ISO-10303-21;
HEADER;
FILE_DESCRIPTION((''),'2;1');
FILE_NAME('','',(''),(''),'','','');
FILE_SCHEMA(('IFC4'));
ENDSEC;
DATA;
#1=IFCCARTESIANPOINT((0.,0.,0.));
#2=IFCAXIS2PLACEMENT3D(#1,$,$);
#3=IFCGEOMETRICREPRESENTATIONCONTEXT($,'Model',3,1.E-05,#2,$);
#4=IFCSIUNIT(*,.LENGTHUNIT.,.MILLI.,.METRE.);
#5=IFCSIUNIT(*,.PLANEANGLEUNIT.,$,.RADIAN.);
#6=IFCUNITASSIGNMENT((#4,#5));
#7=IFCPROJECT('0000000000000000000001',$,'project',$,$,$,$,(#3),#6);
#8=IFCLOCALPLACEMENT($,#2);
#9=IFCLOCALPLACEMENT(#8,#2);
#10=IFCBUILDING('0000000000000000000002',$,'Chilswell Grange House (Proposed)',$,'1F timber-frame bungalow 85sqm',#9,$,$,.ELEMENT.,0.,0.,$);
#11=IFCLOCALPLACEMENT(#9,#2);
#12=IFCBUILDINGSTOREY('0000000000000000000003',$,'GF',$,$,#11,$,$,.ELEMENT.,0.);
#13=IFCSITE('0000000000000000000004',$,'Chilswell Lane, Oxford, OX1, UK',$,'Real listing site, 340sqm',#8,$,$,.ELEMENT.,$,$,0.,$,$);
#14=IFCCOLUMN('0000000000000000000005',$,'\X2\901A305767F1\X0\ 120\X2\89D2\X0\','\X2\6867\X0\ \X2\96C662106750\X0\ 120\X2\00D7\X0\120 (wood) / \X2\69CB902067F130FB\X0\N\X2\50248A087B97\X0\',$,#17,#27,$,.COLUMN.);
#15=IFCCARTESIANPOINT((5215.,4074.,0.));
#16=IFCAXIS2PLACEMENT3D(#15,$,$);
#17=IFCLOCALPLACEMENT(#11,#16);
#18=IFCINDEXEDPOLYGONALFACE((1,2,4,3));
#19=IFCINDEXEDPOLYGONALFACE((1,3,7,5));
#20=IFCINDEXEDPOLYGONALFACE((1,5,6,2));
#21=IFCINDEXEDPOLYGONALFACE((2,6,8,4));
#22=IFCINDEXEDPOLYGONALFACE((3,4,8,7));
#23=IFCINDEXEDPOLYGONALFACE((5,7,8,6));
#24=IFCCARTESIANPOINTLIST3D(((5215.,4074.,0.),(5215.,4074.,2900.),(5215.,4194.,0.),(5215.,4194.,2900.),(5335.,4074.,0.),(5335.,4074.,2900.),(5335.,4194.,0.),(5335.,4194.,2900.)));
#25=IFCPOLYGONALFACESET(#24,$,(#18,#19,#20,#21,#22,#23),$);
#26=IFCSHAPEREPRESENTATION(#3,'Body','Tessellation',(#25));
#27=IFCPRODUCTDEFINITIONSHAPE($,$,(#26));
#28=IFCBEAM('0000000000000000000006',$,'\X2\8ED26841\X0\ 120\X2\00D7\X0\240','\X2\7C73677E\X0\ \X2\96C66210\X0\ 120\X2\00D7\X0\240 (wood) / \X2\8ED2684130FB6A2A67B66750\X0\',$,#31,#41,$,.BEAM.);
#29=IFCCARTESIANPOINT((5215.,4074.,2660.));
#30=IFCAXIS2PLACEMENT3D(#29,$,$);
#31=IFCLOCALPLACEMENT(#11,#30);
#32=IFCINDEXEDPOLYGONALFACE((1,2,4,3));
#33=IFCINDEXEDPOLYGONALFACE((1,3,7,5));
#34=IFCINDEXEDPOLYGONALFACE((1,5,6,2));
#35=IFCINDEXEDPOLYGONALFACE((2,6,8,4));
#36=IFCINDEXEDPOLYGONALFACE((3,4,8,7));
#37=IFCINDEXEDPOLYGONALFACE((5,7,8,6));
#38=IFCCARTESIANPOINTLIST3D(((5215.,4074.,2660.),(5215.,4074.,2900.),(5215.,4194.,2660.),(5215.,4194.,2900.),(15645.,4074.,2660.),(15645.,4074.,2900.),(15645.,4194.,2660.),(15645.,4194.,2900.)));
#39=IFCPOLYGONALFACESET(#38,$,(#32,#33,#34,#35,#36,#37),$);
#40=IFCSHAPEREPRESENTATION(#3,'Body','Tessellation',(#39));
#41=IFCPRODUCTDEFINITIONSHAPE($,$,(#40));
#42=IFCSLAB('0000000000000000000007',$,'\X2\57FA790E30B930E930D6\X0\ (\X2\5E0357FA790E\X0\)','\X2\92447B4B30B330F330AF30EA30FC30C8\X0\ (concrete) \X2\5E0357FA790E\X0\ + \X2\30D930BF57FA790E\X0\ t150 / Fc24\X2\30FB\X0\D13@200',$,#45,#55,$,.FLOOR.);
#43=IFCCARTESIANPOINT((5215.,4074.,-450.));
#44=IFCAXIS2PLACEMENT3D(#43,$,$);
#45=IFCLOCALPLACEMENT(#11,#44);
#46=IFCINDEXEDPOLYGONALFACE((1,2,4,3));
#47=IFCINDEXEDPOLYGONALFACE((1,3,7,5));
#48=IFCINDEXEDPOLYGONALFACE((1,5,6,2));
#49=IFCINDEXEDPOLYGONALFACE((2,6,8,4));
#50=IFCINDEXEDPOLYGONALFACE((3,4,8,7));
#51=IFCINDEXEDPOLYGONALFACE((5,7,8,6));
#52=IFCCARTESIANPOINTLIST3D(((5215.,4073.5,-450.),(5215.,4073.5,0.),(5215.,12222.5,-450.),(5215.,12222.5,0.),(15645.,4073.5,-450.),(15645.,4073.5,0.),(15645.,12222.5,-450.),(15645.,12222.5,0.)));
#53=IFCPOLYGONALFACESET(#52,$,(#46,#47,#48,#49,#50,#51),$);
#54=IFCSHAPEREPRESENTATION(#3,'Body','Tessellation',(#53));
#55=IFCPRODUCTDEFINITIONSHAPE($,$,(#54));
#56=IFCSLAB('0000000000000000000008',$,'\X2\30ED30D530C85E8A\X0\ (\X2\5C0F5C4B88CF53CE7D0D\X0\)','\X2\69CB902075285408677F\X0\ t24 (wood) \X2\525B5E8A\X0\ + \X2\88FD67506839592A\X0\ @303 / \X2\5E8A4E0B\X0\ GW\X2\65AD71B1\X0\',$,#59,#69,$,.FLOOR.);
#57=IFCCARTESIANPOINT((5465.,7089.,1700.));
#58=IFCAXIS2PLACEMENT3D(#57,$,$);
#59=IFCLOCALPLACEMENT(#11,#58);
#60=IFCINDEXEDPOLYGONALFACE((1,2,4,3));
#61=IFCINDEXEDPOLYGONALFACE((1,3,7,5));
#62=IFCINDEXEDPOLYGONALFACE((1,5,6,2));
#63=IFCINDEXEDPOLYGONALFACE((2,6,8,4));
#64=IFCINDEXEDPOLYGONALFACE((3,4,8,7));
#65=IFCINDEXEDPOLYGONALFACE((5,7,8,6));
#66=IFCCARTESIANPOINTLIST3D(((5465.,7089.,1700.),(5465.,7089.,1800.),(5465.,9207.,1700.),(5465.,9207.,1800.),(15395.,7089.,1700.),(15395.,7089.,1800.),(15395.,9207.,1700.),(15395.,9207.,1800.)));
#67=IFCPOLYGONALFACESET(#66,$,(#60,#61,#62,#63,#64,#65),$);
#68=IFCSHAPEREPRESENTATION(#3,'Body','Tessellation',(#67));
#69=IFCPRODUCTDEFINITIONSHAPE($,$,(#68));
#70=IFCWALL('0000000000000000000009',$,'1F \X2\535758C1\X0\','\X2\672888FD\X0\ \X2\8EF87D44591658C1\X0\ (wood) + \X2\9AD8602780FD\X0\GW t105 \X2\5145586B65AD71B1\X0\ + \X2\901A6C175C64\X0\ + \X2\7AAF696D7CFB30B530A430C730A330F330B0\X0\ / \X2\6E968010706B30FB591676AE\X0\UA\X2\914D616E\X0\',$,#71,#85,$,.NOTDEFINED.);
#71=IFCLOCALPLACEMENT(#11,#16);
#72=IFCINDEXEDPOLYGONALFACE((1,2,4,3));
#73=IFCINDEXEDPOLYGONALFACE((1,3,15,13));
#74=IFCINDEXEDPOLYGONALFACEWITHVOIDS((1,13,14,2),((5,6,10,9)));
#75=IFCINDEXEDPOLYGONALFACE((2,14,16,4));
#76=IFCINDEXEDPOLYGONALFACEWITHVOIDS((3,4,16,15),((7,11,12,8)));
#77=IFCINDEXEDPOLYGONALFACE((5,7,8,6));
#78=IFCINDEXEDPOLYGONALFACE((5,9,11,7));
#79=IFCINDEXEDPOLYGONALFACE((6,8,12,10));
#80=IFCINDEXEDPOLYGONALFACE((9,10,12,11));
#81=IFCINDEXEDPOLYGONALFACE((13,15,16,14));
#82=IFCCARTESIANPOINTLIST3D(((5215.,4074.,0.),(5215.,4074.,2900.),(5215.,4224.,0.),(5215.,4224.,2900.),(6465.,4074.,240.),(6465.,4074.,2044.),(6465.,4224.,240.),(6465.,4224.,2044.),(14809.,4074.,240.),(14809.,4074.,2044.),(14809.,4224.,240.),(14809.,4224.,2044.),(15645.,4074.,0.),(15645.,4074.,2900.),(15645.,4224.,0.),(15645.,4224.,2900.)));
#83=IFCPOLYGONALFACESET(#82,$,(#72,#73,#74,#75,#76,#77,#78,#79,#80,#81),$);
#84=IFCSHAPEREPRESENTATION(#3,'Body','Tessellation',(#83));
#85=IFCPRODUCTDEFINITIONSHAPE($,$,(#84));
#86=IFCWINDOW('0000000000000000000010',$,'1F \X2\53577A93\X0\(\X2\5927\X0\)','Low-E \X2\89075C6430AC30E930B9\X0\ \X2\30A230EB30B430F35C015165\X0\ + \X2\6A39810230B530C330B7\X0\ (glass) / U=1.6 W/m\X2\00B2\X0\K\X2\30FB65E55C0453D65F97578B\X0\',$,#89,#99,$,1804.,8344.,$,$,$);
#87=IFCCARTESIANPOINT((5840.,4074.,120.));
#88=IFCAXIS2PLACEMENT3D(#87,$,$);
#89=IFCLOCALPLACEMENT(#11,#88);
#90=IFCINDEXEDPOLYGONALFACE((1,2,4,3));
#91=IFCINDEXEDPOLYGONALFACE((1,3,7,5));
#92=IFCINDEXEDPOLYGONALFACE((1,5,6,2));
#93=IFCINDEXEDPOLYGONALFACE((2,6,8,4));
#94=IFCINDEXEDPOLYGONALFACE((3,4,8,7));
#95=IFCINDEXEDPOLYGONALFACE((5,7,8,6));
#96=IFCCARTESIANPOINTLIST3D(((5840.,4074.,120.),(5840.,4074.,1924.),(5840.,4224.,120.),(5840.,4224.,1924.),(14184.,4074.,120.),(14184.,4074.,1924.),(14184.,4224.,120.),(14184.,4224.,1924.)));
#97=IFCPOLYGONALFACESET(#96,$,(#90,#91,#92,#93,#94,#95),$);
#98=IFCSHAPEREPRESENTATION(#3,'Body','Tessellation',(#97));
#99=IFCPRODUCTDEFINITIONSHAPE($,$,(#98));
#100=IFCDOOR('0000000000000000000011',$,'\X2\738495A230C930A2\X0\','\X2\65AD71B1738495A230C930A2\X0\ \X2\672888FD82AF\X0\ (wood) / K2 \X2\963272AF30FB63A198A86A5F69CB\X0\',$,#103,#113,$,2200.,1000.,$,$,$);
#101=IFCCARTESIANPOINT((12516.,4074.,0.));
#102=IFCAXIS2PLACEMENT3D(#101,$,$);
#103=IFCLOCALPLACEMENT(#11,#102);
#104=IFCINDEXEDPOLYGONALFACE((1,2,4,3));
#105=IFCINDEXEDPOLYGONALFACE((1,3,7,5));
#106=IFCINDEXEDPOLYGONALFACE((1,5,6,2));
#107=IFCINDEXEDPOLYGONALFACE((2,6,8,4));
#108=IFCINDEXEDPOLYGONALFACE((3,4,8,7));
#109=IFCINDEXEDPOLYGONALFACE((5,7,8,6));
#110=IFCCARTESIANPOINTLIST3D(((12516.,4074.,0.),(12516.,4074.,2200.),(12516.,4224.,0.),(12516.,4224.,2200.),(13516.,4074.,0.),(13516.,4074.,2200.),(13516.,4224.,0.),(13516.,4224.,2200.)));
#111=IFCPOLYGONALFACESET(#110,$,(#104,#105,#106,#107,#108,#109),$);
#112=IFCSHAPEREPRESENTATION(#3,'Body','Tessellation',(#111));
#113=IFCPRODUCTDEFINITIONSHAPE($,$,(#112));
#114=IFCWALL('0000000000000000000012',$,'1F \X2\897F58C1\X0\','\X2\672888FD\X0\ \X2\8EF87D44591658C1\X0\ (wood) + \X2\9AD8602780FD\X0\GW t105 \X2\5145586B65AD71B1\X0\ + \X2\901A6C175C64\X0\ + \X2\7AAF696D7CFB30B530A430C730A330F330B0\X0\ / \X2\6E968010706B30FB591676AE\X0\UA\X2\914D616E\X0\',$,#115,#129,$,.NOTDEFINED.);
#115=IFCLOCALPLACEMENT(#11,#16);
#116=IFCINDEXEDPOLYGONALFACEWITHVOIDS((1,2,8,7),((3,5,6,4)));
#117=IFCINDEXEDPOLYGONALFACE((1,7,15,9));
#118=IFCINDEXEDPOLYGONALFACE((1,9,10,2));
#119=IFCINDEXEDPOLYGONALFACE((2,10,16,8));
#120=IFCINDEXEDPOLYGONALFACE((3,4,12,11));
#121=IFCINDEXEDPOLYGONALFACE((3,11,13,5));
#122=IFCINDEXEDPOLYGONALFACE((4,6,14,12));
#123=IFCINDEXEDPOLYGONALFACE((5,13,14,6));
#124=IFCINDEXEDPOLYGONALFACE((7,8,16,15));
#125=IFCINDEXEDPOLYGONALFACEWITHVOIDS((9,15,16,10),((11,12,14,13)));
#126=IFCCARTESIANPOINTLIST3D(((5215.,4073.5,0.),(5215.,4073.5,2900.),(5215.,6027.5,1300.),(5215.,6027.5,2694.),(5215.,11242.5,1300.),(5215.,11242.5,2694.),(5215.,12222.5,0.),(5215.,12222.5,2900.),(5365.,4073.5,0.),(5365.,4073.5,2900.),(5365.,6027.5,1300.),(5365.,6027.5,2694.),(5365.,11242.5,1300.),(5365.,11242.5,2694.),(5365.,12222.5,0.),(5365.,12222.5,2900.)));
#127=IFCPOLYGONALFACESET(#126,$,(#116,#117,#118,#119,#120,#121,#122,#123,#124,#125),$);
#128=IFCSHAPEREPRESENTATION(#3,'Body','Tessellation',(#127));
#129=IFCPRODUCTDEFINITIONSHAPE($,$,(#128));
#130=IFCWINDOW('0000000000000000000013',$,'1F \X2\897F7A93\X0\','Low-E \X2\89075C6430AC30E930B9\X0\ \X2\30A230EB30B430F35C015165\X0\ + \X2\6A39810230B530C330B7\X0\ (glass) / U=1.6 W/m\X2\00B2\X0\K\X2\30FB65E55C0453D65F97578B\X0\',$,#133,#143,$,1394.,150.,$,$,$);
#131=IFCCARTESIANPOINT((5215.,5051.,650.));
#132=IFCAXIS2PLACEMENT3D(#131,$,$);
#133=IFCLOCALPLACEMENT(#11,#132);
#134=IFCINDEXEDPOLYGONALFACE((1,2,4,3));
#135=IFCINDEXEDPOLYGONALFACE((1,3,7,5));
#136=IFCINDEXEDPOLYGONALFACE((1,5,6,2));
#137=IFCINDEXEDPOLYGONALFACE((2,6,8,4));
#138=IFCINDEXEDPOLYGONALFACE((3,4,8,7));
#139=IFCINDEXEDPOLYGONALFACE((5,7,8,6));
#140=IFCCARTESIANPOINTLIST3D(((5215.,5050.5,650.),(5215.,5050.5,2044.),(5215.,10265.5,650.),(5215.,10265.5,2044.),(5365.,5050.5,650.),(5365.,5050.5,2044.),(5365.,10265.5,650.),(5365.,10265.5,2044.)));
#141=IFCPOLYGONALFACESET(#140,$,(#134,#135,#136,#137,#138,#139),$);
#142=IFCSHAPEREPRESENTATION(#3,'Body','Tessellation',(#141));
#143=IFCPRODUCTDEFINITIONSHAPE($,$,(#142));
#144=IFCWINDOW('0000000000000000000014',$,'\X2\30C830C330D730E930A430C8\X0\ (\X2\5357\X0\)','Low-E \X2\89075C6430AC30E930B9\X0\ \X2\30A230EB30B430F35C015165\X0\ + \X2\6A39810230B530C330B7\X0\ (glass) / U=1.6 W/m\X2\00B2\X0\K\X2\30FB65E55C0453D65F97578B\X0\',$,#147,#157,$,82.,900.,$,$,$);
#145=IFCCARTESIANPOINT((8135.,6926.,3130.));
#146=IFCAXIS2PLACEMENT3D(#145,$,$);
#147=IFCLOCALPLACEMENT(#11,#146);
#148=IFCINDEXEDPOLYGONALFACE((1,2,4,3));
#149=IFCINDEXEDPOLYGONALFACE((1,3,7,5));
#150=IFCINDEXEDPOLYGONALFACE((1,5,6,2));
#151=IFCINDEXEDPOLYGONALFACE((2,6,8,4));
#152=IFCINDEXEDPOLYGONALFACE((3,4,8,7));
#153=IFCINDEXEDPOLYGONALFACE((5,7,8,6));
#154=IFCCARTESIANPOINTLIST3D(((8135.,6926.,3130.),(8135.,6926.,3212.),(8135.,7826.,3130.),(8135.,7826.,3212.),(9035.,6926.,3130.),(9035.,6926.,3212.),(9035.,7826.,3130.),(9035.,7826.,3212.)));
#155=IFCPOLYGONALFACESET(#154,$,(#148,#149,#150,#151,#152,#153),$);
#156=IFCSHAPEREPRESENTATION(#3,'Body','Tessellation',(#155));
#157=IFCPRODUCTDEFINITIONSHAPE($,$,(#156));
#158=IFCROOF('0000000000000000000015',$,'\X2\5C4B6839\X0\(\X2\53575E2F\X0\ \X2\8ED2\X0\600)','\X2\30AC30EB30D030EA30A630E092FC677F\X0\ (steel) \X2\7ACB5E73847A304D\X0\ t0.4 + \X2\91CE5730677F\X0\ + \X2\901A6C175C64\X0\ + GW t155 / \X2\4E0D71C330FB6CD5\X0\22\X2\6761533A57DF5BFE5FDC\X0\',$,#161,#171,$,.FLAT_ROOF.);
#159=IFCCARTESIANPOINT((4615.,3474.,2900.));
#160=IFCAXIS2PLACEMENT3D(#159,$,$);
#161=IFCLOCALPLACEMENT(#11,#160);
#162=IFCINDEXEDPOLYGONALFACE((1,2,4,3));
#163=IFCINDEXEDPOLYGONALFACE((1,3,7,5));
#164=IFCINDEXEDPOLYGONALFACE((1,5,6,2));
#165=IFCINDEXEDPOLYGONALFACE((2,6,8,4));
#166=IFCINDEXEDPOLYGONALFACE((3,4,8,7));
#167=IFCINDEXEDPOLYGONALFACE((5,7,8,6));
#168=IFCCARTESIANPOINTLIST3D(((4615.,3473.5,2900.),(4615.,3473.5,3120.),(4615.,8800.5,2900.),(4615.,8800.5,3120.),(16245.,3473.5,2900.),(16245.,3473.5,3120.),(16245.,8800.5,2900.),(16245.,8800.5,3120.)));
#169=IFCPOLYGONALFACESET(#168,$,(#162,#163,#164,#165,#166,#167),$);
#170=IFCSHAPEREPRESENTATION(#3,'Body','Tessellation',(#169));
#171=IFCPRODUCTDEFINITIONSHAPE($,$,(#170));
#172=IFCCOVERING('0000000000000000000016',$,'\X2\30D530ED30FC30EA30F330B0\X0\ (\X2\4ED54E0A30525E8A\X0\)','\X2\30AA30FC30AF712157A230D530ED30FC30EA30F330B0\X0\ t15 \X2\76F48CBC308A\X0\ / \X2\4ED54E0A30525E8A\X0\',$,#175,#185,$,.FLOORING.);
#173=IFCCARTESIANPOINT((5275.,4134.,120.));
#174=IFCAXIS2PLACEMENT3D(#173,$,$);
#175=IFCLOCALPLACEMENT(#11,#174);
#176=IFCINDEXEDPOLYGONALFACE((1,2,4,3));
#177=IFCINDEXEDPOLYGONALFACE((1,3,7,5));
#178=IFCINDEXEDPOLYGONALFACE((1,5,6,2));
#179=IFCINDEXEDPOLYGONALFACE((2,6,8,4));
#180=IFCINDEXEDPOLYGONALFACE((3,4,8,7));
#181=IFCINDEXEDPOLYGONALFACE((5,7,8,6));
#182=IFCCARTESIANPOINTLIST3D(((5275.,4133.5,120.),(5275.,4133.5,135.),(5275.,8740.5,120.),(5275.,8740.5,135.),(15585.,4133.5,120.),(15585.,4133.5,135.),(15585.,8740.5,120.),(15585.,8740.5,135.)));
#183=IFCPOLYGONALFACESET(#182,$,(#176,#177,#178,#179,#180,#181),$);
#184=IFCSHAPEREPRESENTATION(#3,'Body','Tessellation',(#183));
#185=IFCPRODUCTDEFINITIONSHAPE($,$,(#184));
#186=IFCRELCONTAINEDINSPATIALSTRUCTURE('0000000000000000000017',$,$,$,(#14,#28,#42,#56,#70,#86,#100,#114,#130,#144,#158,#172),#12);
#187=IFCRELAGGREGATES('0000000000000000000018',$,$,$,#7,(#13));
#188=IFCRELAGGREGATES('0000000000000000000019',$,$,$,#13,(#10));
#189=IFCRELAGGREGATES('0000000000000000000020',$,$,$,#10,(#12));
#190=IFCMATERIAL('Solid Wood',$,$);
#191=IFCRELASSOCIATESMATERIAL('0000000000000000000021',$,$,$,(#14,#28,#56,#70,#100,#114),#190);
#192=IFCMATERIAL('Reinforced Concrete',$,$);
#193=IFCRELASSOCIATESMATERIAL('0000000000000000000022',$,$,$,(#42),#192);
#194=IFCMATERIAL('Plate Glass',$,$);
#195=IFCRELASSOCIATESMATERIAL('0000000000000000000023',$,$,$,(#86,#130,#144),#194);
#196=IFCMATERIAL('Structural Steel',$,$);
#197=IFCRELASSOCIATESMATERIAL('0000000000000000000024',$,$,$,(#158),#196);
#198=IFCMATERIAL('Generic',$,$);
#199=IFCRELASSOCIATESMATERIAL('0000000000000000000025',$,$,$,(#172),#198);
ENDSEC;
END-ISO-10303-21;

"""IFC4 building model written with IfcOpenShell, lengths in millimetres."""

from ifc_helpers import new_model, si_unit, frame, frame_2d, origin, place, context, project, spatial, rectangle, extrude, material, element, fill, save


model = new_model("IFC4")

# Units and contexts
model_context = context("Model", 3, precision=1e-05, world=origin())
ifc_project = project(units=[si_unit("LENGTHUNIT", "METRE", prefix="MILLI"), si_unit("PLANEANGLEUNIT", "RADIAN")], contexts=[model_context])

# Site, building, storey
site_placement = place(None, origin())
site = spatial("IfcSite", under=ifc_project, at=site_placement, Name="Chilswell Lane, Oxford, OX1, UK", ObjectType="Real listing site, 340sqm", CompositionType="ELEMENT", RefElevation=0.0)
building_placement = place(site_placement, origin())
building = spatial("IfcBuilding", under=site, at=building_placement, Name="Chilswell Grange House (Proposed)", ObjectType="1F timber-frame bungalow 85sqm", CompositionType="ELEMENT", ElevationOfRefHeight=0.0, ElevationOfTerrain=0.0)
storey_placement = place(building_placement, origin())
storey = spatial("IfcBuildingStorey", under=building, at=storey_placement, Name="GF", CompositionType="ELEMENT", Elevation=0.0)

# Column
ifc_material_1 = material(Name="Solid Wood")
column_1_placement = place(storey_placement, frame((5215.0, 4074.0, 0.0)))
element("IfcColumn", 1, at=column_1_placement, inside=storey, material=ifc_material_1, Name="通し柱 120角", Description="桧 集成材 120×120 (wood) / 構造柱・N値計算", PredefinedType="COLUMN", context=model_context, shape_type="SweptSolid", body=[
    extrude(rectangle(XDim=120.0, YDim=120.0, at=frame_2d((60.0, 60.0))), frame((5215.0, 4074.0, 0.0)), (0.0, 0.0, 1.0), 2900.0),
])

# Beam
beam_1_placement = place(storey_placement, frame((5215.0, 4074.0, 2660.0)))
element("IfcBeam", 2, at=beam_1_placement, inside=storey, material=ifc_material_1, Name="軒桁 120×240", Description="米松 集成 120×240 (wood) / 軒桁・横架材", PredefinedType="BEAM", context=model_context, shape_type="SweptSolid", body=[
    extrude(rectangle(XDim=10430.0, YDim=120.0, at=frame_2d((5215.0, 60.0))), frame((5215.0, 4074.0, 2660.0)), (0.0, 0.0, 1.0), 240.0),
])

# Slabs
ifc_material_2 = material(Name="Reinforced Concrete")
slab_1_placement = place(storey_placement, frame((5215.0, 4074.0, -450.0)))
element("IfcSlab", 3, at=slab_1_placement, inside=storey, material=ifc_material_2, Name="基礎スラブ (布基礎)", Description="鉄筋コンクリート (concrete) 布基礎 + ベタ基礎 t150 / Fc24・D13@200", PredefinedType="FLOOR", context=model_context, shape_type="SweptSolid", body=[
    extrude(rectangle(XDim=10430.0, YDim=8149.0, at=frame_2d((5215.0, 4074.0))), frame((5215.0, 4074.0, -450.0)), (0.0, 0.0, 1.0), 450.0),
])
slab_2_placement = place(storey_placement, frame((5465.0, 7089.0, 1700.0)))
element("IfcSlab", 4, at=slab_2_placement, inside=storey, material=ifc_material_1, Name="ロフト床 (小屋裏収納)", Description="構造用合板 t24 (wood) 剛床 + 製材根太 @303 / 床下 GW断熱", PredefinedType="FLOOR", context=model_context, shape_type="SweptSolid", body=[
    extrude(rectangle(XDim=9930.0, YDim=2118.0, at=frame_2d((4965.0, 1059.0))), frame((5465.0, 7089.0, 1700.0)), (0.0, 0.0, 1.0), 100.0),
])

# Wall, openings, window, door
wall_1_placement = place(storey_placement, frame((5215.0, 4074.0, 0.0)))
wall_1 = element("IfcWall", 5, at=wall_1_placement, inside=storey, material=ifc_material_1, Name="1F 南壁", Description="木製 軸組外壁 (wood) + 高性能GW t105 充填断熱 + 通気層 + 窯業系サイディング / 準耐火・外皮UA配慮", PredefinedType="NOTDEFINED", context=model_context, shape_type="SweptSolid", body=[
    extrude(rectangle(XDim=10430.0, YDim=150.0, at=frame_2d((5215.0, 75.0))), frame((5215.0, 4074.0, 0.0)), (0.0, 0.0, 1.0), 2900.0),
])
opening_1_placement = place(storey_placement, frame((5840.0, 4074.0, 120.0)))
opening_1 = element("IfcOpeningElement", 6, at=opening_1_placement, cuts=wall_1, PredefinedType="NOTDEFINED", context=model_context, shape_type="SweptSolid", body=[
    extrude(rectangle(XDim=8344.0, YDim=150.0, at=frame_2d((4172.0, 75.0))), frame((5840.0, 4074.0, 120.0)), (0.0, 0.0, 1.0), 1804.0),
])
opening_2_placement = place(storey_placement, frame((12516.0, 4074.0, 0.0)))
opening_2 = element("IfcOpeningElement", 7, at=opening_2_placement, cuts=wall_1, PredefinedType="NOTDEFINED", context=model_context, shape_type="SweptSolid", body=[
    extrude(rectangle(XDim=1000.0, YDim=150.0, at=frame_2d((500.0, 75.0))), frame((12516.0, 4074.0, 0.0)), (0.0, 0.0, 1.0), 2200.0),
])
ifc_material_3 = material(Name="Plate Glass")
window_1_placement = place(storey_placement, frame((5840.0, 4074.0, 120.0)))
window_1 = element("IfcWindow", 8, at=window_1_placement, inside=storey, material=ifc_material_3, Name="1F 南窓(大)", Description="Low-E 複層ガラス アルゴン封入 + 樹脂サッシ (glass) / U=1.6 W/m²K・日射取得型", OverallHeight=1804.0, OverallWidth=8344.0, context=model_context, shape_type="SweptSolid", body=[
    extrude(rectangle(XDim=8344.0, YDim=150.0, at=frame_2d((4172.0, 75.0))), frame((5840.0, 4074.0, 120.0)), (0.0, 0.0, 1.0), 1804.0),
])
fill(opening_1, window_1)
door_placement = place(storey_placement, frame((12516.0, 4074.0, 0.0)))
door = element("IfcDoor", 9, at=door_placement, inside=storey, material=ifc_material_1, Name="玄関ドア", Description="断熱玄関ドア 木製芯 (wood) / K2 防犯・採風機構", OverallHeight=2200.0, OverallWidth=1000.0, context=model_context, shape_type="SweptSolid", body=[
    extrude(rectangle(XDim=1000.0, YDim=150.0, at=frame_2d((500.0, 75.0))), frame((12516.0, 4074.0, 0.0)), (0.0, 0.0, 1.0), 2200.0),
])
fill(opening_2, door)

# Wall, opening, window
wall_2_placement = place(storey_placement, frame((5215.0, 4074.0, 0.0)))
wall_2 = element("IfcWall", 10, at=wall_2_placement, inside=storey, material=ifc_material_1, Name="1F 西壁", Description="木製 軸組外壁 (wood) + 高性能GW t105 充填断熱 + 通気層 + 窯業系サイディング / 準耐火・外皮UA配慮", PredefinedType="NOTDEFINED", context=model_context, shape_type="SweptSolid", body=[
    extrude(rectangle(XDim=150.0, YDim=8149.0, at=frame_2d((75.0, 4074.0))), frame((5215.0, 4074.0, 0.0)), (0.0, 0.0, 1.0), 2900.0),
])
opening_3_placement = place(storey_placement, frame((5215.0, 5051.0, 650.0)))
opening_3 = element("IfcOpeningElement", 11, at=opening_3_placement, cuts=wall_2, PredefinedType="NOTDEFINED", context=model_context, shape_type="SweptSolid", body=[
    extrude(rectangle(XDim=150.0, YDim=5215.0, at=frame_2d((75.0, 2607.0))), frame((5215.0, 5051.0, 650.0)), (0.0, 0.0, 1.0), 1394.0),
])
window_2_placement = place(storey_placement, frame((5215.0, 5051.0, 650.0)))
window_2 = element("IfcWindow", 12, at=window_2_placement, inside=storey, material=ifc_material_3, Name="1F 西窓", Description="Low-E 複層ガラス アルゴン封入 + 樹脂サッシ (glass) / U=1.6 W/m²K・日射取得型", OverallHeight=1394.0, OverallWidth=150.0, context=model_context, shape_type="SweptSolid", body=[
    extrude(rectangle(XDim=150.0, YDim=5215.0, at=frame_2d((75.0, 2607.0))), frame((5215.0, 5051.0, 650.0)), (0.0, 0.0, 1.0), 1394.0),
])
fill(opening_3, window_2)

# Window
window_3_placement = place(storey_placement, frame((8135.0, 6926.0, 3130.0)))
element("IfcWindow", 13, at=window_3_placement, inside=storey, material=ifc_material_3, Name="トップライト (南)", Description="Low-E 複層ガラス アルゴン封入 + 樹脂サッシ (glass) / U=1.6 W/m²K・日射取得型", OverallHeight=82.0, OverallWidth=900.0, context=model_context, shape_type="SweptSolid", body=[
    extrude(rectangle(XDim=900.0, YDim=900.0, at=frame_2d((450.0, 450.0))), frame((8135.0, 6926.0, 3130.0)), (0.0, 0.0, 1.0), 82.0),
])

# Roof
ifc_material_4 = material(Name="Structural Steel")
roof_placement = place(storey_placement, frame((4615.0, 3474.0, 2900.0)))
element("IfcRoof", 14, at=roof_placement, inside=storey, material=ifc_material_4, Name="屋根(南帯 軒600)", Description="ガルバリウム鋼板 (steel) 立平葺き t0.4 + 野地板 + 通気層 + GW t155 / 不燃・法22条区域対応", PredefinedType="FLAT_ROOF", context=model_context, shape_type="SweptSolid", body=[
    extrude(rectangle(XDim=11630.0, YDim=5327.0, at=frame_2d((5815.0, 2663.0))), frame((4615.0, 3474.0, 2900.0)), (0.0, 0.0, 1.0), 220.0),
])

# Covering
ifc_material_5 = material(Name="Generic")
covering_1_placement = place(storey_placement, frame((5275.0, 4134.0, 120.0)))
element("IfcCovering", 15, at=covering_1_placement, inside=storey, material=ifc_material_5, Name="フローリング (仕上げ床)", Description="オーク無垢フローリング t15 直貼り / 仕上げ床", PredefinedType="FLOORING", context=model_context, shape_type="SweptSolid", body=[
    extrude(rectangle(XDim=10310.0, YDim=4607.0, at=frame_2d((5155.0, 2303.0))), frame((5275.0, 4134.0, 120.0)), (0.0, 0.0, 1.0), 15.0),
])

save(model, "model.ifc")
